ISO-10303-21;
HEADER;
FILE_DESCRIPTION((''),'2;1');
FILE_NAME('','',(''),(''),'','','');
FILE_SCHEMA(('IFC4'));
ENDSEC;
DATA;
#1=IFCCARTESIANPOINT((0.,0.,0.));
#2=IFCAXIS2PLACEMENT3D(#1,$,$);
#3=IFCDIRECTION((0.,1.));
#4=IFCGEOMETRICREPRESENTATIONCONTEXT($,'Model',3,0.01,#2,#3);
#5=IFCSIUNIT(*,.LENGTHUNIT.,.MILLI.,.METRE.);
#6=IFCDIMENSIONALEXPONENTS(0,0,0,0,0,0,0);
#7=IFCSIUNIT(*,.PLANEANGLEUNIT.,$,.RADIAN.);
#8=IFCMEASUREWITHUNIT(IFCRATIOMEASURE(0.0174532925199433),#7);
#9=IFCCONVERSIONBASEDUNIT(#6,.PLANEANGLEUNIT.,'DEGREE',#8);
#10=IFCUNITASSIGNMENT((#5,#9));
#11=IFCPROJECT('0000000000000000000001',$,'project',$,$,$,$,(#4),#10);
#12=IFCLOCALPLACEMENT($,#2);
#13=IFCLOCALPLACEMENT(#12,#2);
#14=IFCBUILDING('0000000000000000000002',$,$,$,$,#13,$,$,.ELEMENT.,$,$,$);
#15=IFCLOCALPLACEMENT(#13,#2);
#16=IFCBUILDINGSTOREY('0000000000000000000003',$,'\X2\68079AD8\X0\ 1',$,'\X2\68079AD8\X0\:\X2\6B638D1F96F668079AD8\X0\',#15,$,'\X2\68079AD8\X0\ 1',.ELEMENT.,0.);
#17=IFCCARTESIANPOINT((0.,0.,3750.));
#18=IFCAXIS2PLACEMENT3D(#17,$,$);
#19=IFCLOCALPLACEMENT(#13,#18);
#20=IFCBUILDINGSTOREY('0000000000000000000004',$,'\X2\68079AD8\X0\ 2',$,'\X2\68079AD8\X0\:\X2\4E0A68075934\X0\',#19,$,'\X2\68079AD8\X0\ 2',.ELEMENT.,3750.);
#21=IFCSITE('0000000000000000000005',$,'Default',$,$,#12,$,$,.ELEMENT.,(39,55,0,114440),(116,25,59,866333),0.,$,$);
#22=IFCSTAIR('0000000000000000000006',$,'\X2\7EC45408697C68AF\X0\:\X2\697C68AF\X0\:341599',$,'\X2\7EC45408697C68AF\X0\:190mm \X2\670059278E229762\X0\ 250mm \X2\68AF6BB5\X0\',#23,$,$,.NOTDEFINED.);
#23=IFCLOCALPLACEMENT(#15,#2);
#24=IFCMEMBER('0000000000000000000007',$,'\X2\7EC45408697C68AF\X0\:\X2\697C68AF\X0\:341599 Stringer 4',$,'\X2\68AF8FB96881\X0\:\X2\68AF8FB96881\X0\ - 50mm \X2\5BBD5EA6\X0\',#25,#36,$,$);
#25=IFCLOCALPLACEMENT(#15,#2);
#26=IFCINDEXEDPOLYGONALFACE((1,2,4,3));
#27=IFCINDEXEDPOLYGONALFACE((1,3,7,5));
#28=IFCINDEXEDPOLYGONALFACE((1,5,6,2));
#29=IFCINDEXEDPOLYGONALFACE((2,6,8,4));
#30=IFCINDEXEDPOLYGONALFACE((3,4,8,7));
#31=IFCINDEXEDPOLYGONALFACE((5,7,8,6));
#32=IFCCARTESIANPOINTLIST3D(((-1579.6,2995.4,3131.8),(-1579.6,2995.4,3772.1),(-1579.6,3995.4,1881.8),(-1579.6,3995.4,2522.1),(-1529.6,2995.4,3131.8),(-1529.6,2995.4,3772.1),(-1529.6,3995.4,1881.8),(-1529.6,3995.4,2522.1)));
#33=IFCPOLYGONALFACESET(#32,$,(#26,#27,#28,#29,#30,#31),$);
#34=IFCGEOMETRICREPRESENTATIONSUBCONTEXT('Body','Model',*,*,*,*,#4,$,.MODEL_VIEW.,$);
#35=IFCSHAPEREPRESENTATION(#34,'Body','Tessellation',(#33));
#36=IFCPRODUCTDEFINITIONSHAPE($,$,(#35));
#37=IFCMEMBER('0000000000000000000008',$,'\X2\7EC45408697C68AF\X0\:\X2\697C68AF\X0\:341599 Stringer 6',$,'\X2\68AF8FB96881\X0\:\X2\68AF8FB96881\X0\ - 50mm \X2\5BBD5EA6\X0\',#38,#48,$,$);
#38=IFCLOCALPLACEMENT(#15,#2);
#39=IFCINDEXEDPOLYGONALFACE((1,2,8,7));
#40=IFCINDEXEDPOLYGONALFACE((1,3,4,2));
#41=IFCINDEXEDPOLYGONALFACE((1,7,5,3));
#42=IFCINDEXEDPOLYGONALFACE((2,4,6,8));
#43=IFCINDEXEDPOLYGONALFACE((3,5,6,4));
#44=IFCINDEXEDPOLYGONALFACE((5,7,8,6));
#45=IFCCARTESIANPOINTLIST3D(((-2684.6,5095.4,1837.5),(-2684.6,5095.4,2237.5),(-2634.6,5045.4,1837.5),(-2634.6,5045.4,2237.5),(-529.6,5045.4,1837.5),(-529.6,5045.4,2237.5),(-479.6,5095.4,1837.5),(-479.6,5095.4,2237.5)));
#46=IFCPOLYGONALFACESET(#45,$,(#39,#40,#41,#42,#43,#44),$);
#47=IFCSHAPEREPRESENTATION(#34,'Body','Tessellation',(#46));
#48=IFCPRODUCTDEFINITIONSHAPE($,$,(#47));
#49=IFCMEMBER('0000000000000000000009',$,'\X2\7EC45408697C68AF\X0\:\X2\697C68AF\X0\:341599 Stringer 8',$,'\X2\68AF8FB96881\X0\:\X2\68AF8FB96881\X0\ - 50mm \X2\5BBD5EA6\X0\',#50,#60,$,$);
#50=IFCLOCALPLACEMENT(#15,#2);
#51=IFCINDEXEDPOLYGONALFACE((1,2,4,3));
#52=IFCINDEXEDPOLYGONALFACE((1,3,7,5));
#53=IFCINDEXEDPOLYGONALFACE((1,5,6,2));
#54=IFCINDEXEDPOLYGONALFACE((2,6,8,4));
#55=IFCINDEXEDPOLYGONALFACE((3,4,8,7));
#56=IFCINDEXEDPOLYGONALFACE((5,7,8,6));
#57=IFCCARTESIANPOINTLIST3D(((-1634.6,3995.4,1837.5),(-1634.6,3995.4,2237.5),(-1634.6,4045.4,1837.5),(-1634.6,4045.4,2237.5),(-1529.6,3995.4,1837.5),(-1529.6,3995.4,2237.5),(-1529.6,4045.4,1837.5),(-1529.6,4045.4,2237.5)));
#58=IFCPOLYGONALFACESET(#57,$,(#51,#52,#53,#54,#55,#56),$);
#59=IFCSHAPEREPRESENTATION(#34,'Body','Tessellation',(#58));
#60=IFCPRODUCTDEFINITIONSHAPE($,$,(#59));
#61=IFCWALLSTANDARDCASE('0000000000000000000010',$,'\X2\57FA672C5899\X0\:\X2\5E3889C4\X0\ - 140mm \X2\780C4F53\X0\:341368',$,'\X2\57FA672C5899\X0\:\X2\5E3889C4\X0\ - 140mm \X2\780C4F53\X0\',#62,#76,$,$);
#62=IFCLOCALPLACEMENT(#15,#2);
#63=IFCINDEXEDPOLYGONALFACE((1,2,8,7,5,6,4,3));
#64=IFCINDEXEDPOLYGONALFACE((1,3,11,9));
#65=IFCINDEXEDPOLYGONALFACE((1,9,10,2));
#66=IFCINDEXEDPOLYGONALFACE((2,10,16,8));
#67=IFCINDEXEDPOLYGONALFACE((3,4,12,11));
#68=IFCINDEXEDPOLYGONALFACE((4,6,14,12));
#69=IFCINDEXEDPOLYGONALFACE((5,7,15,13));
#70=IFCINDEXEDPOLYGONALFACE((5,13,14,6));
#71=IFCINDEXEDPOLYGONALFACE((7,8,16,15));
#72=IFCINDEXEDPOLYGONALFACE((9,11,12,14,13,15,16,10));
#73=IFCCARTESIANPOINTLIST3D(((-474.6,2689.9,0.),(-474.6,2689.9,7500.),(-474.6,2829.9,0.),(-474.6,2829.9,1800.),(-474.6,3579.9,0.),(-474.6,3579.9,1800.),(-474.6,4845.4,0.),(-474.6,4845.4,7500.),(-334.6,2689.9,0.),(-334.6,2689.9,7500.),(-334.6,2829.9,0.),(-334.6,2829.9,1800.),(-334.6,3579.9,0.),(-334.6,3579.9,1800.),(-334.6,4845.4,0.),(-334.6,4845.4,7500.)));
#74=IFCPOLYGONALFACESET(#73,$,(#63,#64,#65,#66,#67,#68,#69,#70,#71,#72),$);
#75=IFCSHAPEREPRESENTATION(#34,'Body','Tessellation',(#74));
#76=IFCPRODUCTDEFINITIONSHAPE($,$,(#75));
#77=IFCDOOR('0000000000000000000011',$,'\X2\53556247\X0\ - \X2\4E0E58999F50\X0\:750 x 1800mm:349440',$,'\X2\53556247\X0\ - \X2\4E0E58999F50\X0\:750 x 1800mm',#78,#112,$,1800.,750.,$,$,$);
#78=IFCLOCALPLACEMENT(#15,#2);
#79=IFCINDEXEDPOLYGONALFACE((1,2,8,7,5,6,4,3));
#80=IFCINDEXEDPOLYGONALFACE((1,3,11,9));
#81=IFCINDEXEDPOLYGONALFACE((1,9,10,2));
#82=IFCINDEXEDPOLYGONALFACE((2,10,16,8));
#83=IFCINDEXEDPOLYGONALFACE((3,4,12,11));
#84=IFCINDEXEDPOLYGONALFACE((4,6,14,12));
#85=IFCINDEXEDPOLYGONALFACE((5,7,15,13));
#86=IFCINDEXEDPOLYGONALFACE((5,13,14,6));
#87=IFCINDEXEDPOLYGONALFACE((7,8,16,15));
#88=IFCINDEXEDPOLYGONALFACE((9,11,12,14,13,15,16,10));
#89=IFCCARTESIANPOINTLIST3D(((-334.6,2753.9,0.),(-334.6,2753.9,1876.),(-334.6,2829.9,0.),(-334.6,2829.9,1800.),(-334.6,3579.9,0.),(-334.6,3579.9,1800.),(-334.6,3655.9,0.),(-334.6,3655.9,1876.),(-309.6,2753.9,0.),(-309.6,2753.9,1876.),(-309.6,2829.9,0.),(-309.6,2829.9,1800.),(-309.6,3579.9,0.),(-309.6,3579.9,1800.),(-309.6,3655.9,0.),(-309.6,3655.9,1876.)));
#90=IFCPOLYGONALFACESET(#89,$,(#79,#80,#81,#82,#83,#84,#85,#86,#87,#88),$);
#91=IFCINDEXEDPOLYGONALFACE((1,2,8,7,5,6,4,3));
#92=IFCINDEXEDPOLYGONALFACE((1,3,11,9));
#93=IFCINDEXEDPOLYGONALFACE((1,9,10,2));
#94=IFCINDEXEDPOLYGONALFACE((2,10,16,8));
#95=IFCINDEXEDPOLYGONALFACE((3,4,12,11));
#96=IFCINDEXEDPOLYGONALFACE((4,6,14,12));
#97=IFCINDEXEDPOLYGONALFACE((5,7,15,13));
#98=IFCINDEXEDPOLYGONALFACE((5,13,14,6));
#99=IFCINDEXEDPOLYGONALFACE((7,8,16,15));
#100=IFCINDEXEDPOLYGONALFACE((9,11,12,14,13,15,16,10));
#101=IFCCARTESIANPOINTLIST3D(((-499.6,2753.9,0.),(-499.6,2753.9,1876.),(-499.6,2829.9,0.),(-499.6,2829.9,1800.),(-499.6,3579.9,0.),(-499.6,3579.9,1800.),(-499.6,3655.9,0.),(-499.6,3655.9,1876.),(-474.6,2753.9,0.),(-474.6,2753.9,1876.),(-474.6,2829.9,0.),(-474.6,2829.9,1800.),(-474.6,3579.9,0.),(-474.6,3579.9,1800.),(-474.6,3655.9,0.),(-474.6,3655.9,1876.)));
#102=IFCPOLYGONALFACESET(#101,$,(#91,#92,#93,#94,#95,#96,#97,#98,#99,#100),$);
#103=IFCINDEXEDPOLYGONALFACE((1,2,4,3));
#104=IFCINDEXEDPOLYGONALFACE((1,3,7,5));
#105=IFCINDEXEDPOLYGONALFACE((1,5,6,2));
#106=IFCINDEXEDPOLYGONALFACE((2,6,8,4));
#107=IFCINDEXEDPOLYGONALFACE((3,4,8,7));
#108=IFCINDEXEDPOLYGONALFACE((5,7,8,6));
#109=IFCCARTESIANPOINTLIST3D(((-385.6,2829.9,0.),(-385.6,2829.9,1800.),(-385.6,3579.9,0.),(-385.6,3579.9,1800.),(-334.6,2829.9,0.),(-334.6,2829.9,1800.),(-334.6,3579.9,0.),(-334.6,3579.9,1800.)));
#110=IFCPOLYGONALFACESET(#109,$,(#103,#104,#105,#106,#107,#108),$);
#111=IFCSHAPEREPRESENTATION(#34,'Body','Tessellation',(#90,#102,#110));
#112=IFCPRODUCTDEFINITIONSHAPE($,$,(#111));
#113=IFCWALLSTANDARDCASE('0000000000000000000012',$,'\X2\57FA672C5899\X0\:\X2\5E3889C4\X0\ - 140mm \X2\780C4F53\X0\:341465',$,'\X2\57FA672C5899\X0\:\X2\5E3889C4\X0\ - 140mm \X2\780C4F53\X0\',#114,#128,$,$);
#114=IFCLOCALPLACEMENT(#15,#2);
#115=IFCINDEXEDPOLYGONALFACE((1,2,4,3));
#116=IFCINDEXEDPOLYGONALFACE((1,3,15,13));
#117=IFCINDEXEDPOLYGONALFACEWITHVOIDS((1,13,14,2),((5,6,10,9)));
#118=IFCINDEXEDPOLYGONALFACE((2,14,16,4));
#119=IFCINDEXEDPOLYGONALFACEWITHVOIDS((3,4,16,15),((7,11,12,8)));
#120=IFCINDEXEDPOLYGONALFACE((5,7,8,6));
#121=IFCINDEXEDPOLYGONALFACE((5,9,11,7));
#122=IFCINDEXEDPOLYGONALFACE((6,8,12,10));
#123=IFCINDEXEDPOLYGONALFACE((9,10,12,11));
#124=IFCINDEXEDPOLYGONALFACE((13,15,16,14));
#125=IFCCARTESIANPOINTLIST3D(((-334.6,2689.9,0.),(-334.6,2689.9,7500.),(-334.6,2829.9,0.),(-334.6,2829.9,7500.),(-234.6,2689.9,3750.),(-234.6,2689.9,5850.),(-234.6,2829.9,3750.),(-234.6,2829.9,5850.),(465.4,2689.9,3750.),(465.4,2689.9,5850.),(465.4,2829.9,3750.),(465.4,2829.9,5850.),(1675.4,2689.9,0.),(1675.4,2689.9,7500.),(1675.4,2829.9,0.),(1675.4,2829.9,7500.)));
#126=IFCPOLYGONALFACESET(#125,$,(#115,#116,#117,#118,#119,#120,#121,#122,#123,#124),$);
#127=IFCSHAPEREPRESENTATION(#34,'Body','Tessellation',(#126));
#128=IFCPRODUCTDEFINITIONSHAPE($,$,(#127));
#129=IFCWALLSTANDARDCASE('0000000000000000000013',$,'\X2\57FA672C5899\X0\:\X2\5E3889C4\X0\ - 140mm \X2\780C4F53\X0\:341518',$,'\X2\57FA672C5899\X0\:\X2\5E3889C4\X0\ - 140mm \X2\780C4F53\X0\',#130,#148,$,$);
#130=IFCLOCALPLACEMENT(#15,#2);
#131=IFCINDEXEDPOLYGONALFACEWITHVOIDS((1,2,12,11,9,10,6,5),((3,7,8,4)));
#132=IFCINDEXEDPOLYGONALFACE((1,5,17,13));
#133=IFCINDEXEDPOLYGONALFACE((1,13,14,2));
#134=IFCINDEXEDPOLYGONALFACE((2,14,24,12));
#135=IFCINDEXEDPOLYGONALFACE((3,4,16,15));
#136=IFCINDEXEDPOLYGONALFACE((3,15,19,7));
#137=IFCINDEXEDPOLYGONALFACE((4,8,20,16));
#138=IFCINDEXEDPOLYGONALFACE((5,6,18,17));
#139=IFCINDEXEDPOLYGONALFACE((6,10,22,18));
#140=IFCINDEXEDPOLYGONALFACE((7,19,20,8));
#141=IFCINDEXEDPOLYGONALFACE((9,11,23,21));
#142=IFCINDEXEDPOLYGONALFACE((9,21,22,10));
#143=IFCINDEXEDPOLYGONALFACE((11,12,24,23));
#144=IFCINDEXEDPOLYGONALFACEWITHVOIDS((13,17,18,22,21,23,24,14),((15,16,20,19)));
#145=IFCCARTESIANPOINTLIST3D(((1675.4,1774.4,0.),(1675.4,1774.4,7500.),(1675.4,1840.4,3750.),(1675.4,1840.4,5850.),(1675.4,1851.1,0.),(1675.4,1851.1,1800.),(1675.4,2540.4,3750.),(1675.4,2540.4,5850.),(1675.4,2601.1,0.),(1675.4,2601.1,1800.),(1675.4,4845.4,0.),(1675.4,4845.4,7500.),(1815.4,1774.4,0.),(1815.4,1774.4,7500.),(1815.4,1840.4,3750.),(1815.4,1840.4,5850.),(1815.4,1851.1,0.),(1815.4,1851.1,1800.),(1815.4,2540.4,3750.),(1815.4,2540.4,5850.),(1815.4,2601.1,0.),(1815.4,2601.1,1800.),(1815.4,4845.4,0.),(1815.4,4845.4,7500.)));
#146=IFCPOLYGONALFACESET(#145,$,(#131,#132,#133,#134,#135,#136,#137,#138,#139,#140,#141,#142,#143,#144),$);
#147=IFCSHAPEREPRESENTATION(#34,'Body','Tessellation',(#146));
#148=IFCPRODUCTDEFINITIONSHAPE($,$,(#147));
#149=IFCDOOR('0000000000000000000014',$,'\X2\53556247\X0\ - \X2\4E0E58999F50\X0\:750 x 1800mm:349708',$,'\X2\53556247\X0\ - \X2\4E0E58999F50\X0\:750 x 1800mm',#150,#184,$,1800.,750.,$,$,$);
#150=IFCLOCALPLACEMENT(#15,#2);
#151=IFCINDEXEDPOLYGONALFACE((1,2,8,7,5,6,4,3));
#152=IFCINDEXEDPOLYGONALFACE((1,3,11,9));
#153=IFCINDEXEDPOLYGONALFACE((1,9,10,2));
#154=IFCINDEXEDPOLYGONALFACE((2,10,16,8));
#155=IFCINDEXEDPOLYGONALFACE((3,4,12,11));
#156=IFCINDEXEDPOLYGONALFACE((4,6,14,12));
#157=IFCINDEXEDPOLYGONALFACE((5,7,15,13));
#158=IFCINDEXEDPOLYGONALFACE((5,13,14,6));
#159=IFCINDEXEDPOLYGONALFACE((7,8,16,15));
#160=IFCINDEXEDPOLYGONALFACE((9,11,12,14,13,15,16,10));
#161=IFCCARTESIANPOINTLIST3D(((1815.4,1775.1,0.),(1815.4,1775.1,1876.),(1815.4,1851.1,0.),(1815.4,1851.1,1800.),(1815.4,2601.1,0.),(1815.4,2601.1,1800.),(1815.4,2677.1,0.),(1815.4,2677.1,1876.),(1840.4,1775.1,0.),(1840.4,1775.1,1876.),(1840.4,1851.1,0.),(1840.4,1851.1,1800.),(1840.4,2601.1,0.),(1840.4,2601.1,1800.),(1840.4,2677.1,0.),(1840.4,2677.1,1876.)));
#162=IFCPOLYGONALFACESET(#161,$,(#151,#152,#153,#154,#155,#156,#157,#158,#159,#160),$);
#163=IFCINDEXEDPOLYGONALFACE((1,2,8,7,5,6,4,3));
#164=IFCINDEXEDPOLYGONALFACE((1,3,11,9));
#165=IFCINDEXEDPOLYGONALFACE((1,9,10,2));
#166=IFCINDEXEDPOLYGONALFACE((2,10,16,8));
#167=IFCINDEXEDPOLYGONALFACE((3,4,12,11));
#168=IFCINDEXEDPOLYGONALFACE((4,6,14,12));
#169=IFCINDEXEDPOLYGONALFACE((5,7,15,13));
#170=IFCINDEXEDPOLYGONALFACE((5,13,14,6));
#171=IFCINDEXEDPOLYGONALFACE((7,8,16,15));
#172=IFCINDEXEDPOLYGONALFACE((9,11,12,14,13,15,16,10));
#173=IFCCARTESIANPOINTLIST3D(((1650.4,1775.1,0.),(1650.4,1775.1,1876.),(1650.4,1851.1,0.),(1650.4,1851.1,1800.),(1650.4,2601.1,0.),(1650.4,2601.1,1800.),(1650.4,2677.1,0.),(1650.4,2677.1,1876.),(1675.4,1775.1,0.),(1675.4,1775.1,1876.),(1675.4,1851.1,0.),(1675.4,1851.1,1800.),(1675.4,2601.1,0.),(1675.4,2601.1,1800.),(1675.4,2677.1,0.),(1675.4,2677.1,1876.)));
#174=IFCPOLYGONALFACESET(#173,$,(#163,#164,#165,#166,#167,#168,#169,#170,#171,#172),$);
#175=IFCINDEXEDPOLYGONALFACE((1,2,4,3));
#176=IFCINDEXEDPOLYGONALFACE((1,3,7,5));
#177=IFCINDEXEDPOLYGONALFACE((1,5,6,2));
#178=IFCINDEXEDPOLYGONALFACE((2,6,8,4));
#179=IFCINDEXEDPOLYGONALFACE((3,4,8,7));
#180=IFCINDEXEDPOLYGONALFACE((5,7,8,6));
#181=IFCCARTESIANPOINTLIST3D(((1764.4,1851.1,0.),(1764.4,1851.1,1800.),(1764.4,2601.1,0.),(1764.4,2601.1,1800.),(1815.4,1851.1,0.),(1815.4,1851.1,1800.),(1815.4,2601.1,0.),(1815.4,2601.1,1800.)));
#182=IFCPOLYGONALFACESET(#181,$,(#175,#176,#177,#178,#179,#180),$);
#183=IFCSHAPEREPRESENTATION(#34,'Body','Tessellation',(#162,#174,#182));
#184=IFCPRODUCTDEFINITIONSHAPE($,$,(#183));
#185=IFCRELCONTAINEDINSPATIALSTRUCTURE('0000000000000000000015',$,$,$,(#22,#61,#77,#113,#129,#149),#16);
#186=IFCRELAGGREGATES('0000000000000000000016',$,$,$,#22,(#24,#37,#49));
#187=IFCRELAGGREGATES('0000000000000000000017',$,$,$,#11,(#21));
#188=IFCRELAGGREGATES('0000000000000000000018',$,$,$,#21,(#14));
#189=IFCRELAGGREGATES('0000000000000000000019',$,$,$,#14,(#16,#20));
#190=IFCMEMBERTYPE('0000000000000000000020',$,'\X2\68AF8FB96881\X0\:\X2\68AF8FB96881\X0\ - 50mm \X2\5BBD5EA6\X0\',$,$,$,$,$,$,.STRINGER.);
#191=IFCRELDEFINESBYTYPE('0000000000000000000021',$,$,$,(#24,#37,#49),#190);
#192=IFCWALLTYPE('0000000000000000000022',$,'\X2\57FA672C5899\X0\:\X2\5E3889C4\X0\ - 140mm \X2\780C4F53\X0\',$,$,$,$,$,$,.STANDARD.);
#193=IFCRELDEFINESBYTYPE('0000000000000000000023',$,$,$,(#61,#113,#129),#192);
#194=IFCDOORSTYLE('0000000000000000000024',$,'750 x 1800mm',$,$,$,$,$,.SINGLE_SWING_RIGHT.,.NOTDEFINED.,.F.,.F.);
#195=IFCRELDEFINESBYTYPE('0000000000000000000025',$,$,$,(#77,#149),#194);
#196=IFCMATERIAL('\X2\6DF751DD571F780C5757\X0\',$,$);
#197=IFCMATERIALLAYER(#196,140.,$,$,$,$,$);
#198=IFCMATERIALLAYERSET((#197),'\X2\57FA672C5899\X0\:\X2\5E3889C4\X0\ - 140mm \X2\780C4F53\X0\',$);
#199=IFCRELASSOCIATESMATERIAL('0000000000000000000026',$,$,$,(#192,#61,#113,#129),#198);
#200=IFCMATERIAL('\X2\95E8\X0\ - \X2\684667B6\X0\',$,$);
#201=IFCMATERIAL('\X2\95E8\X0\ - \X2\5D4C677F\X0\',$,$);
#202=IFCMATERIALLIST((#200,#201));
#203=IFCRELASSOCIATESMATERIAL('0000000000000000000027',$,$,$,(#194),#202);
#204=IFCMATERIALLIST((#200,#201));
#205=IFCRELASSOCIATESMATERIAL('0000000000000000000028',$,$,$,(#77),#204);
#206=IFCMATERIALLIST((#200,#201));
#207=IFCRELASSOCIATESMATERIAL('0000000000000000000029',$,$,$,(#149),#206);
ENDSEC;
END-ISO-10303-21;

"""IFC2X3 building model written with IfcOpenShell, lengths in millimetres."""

from ifc_helpers import new_model, entity, si_unit, converted_unit, direction, frame, frame_2d, origin, place, context, subcontext, project, spatial, polyline, rectangle, outline, extrude, source, transform, mapped, material, material_list, layer, layer_set, layer_usage, type_object, type_shapes, element, fill, aggregate, save


model = new_model("IFC2X3")

# Units and contexts
model_context = context("Model", 3, precision=0.01, world=origin(), true_north=direction((0.0, 1.0)))
body_context = subcontext(model_context, "Body", "Model", "MODEL_VIEW")
ifc_project = project(units=[si_unit("LENGTHUNIT", "METRE", prefix="MILLI"), converted_unit("PLANEANGLEUNIT", "DEGREE", entity("IfcRatioMeasure", 0.0174532925199433), si_unit("PLANEANGLEUNIT", "RADIAN"), dimensions=[0, 0, 0, 0, 0, 0, 0])], contexts=[model_context])

# Site, building, storey
site_placement = place(None, origin())
site = spatial("IfcSite", under=ifc_project, at=site_placement, Name="Default", CompositionType="ELEMENT", RefLatitude=(39, 55, 0, 114440), RefLongitude=(116, 25, 59, 866333), RefElevation=0.0)
building_placement = place(site_placement, origin())
building = spatial("IfcBuilding", under=site, at=building_placement, CompositionType="ELEMENT")
storey_1_placement = place(building_placement, origin())
storey_1 = spatial("IfcBuildingStorey", under=building, at=storey_1_placement, Name="标高 1", ObjectType="标高:正负零标高", LongName="标高 1", CompositionType="ELEMENT", Elevation=0.0)

# Stair, members
stair_placement = place(storey_1_placement, origin())
stair = element("IfcStair", 1, at=stair_placement, inside=storey_1, Name="组合楼梯:楼梯:341599", ObjectType="组合楼梯:190mm 最大踢面 250mm 梯段", ShapeType="NOTDEFINED")
member_type = type_object("IfcMemberType", Name="梯边梁:梯边梁 - 50mm 宽度", PredefinedType="STRINGER")
member_1_placement = place(stair_placement, origin())
member_1 = element("IfcMember", 2, at=member_1_placement, type_object=member_type, Name="组合楼梯:楼梯:341599 Stringer 4", ObjectType="梯边梁:梯边梁 - 50mm 宽度", context=body_context, shape_type="SweptSolid", body=[
    extrude(outline(polyline([(-550.4, -200.0), (1050.4, -200.0), (550.4, 200.0), (-1050.4, 200.0), (-550.4, -200.0)])), frame((-1579.6, 3495.4, 2826.9), z_axis=(1.0, 0.0, 0.0), x_axis=(0.0, -0.624695, 0.780869)), (0.0, 0.0, 1.0), 50.0),
])
member_2_placement = place(stair_placement, origin())
member_2 = element("IfcMember", 3, at=member_2_placement, type_object=member_type, Name="组合楼梯:楼梯:341599 Stringer 6", ObjectType="梯边梁:梯边梁 - 50mm 宽度", context=body_context, shape_type="SweptSolid", body=[
    extrude(outline(polyline([(-1102.5, -25.0), (1102.5, -25.0), (1052.5, 25.0), (-1052.5, 25.0), (-1102.5, -25.0)])), frame((-1582.1, 5070.4, 1837.5), z_axis=(0.0, 0.0, 1.0), x_axis=(-1.0, 0.0, 0.0)), (0.0, 0.0, 1.0), 400.0),
])
member_3_placement = place(stair_placement, origin())
member_3 = element("IfcMember", 4, at=member_3_placement, type_object=member_type, Name="组合楼梯:楼梯:341599 Stringer 8", ObjectType="梯边梁:梯边梁 - 50mm 宽度", context=body_context, shape_type="SweptSolid", body=[
    extrude(rectangle(XDim=105.0, YDim=50.0, at=frame_2d((0.0, 0.0), x_axis=(1.0, 0.0))), frame((-1582.1, 4020.4, 1837.5)), (0.0, 0.0, 1.0), 400.0),
])

# Shared definitions
ifc_material_1 = material(Name="混凝土砌块")
ifc_layer_1 = layer(ifc_material_1, 140.0)
ifc_layer_set_1 = layer_set([ifc_layer_1], Name="基本墙:常规 - 140mm 砌体")
wall_type = type_object("IfcWallType", Name="基本墙:常规 - 140mm 砌体", PredefinedType="STANDARD", material=ifc_layer_set_1)

# Shared definitions
storey_2_placement = place(building_placement, frame((0.0, 0.0, 3750.0)))
storey_2 = spatial("IfcBuildingStorey", under=building, at=storey_2_placement, Name="标高 2", ObjectType="标高:上标头", LongName="标高 2", CompositionType="ELEMENT", Elevation=3750.0)

# Shared definitions
ifc_material_2 = material(Name="门 - 框架")
ifc_material_3 = material(Name="门 - 嵌板")

# Wall, opening, door
ifc_layer_usage_1 = layer_usage(ifc_layer_set_1, "AXIS2", "NEGATIVE", 70.0)
wall_1_placement = place(storey_1_placement, frame((-404.6, 2689.9, 0.0), z_axis=(0.0, 0.0, 1.0), x_axis=(0.0, 1.0, 0.0)))
wall_1 = element("IfcWallStandardCase", 5, at=wall_1_placement, inside=storey_1, type_object=wall_type, material=ifc_layer_usage_1, Name="基本墙:常规 - 140mm 砌体:341368", ObjectType="基本墙:常规 - 140mm 砌体", context=body_context, shape_type="SweptSolid", body=[
    extrude(rectangle(XDim=2155.5, YDim=140.0, at=frame_2d((1077.8, 0.0), x_axis=(-1.0, 0.0))), origin(), (0.0, 0.0, 1.0), 7500.0),
])
opening_1_placement = place(wall_1_placement, frame((890.0, 70.0, 0.0)))
opening_1 = element("IfcOpeningElement", 6, at=opening_1_placement, cuts=wall_1, ObjectType="Opening", context=body_context, shape_type="SweptSolid", body=[
    extrude(rectangle(XDim=750.0, YDim=1800.0, at=frame_2d((900.0, 375.0), x_axis=(0.0, 1.0))), frame((0.0, 0.0, 0.0), z_axis=(0.0, -1.0, 0.0), x_axis=(0.0, 0.0, 1.0)), (0.0, 0.0, 1.0), 140.0),
])
ifc_material_list_1 = material_list([ifc_material_2, ifc_material_3])
ifc_material_list_2 = material_list([ifc_material_2, ifc_material_3])
door_style_1 = type_object("IfcDoorStyle", Name="750 x 1800mm", ConstructionType="NOTDEFINED", OperationType="SINGLE_SWING_RIGHT", ParameterTakesPrecedence=False, Sizeable=False, material=ifc_material_list_2)
shared_shape_1 = source(origin(), body_context, "Body", "SweptSolid", [
    extrude(outline(polyline([(-451.0, -957.0), (451.0, -957.0), (451.0, 919.0), (375.0, 919.0), (375.0, -881.0), (-375.0, -881.0), (-375.0, 919.0), (-451.0, 919.0), (-451.0, -957.0)])), frame((375.0, 140.0, 919.0), z_axis=(0.0, 1.0, 0.0), x_axis=(1.0, 0.0, 0.0)), (0.0, 0.0, 1.0), 25.0),
    extrude(outline(polyline([(-957.0, -451.0), (919.0, -451.0), (919.0, -375.0), (-881.0, -375.0), (-881.0, 375.0), (919.0, 375.0), (919.0, 451.0), (-957.0, 451.0), (-957.0, -451.0)])), frame((375.0, -25.0, 919.0), z_axis=(0.0, 1.0, 0.0), x_axis=(0.0, 0.0, -1.0)), (0.0, 0.0, 1.0), 25.0),
    extrude(rectangle(XDim=51.0, YDim=750.0, at=frame_2d((0.0, 0.0), x_axis=(1.0, 0.0))), frame((375.0, 114.5, 0.0), z_axis=(0.0, 0.0, 1.0), x_axis=(0.0, 1.0, 0.0)), (0.0, 0.0, 1.0), 1800.0),
])
type_shapes(door_style_1, [shared_shape_1])
door_1_placement = place(opening_1_placement, frame((0.0, 0.0, 0.0), z_axis=(0.0, 0.0, 1.0), x_axis=(-1.0, 0.0, 0.0)))
door_1 = element("IfcDoor", 7, at=door_1_placement, inside=storey_1, type_object=door_style_1, material=ifc_material_list_1, Name="单扇 - 与墙齐:750 x 1800mm:349440", ObjectType="单扇 - 与墙齐:750 x 1800mm", OverallHeight=1800.0, OverallWidth=750.0, context=body_context, shape_type="MappedRepresentation", body=[
    mapped(shared_shape_1, transform((0.0, 0.0, 0.0), scale=1.0)),
])
fill(opening_1, door_1)

# Wall, opening
ifc_layer_usage_2 = layer_usage(ifc_layer_set_1, "AXIS2", "NEGATIVE", 70.0)
wall_2_placement = place(storey_1_placement, frame((-334.6, 2759.9, 0.0)))
wall_2 = element("IfcWallStandardCase", 8, at=wall_2_placement, inside=storey_1, type_object=wall_type, material=ifc_layer_usage_2, Name="基本墙:常规 - 140mm 砌体:341465", ObjectType="基本墙:常规 - 140mm 砌体", context=body_context, shape_type="SweptSolid", body=[
    extrude(rectangle(XDim=2010.0, YDim=140.0, at=frame_2d((1005.0, 0.0), x_axis=(-1.0, 0.0))), origin(), (0.0, 0.0, 1.0), 7500.0),
])
opening_2_placement = place(wall_2_placement, frame((100.0, -70.0, 3750.0)))
element("IfcOpeningElement", 9, at=opening_2_placement, cuts=wall_2, ObjectType="Opening", context=body_context, shape_type="SweptSolid", body=[
    extrude(rectangle(XDim=2100.0, YDim=700.0, at=frame_2d((1050.0, 350.0), x_axis=(1.0, 0.0))), frame((0.0, 0.0, 0.0), z_axis=(0.0, 1.0, 0.0), x_axis=(0.0, 0.0, 1.0)), (0.0, 0.0, 1.0), 140.0),
])

# Wall, openings, door
ifc_layer_usage_3 = layer_usage(ifc_layer_set_1, "AXIS2", "NEGATIVE", 70.0)
wall_3_placement = place(storey_1_placement, frame((1745.4, 1774.4, 0.0), z_axis=(0.0, 0.0, 1.0), x_axis=(0.0, 1.0, 0.0)))
wall_3 = element("IfcWallStandardCase", 10, at=wall_3_placement, inside=storey_1, type_object=wall_type, material=ifc_layer_usage_3, Name="基本墙:常规 - 140mm 砌体:341518", ObjectType="基本墙:常规 - 140mm 砌体", context=body_context, shape_type="SweptSolid", body=[
    extrude(rectangle(XDim=3071.0, YDim=140.0, at=frame_2d((1535.5, 0.0), x_axis=(-1.0, 0.0))), origin(), (0.0, 0.0, 1.0), 7500.0),
])
opening_3_placement = place(wall_3_placement, frame((826.8, 70.0, 0.0)))
opening_3 = element("IfcOpeningElement", 11, at=opening_3_placement, cuts=wall_3, ObjectType="Opening", context=body_context, shape_type="SweptSolid", body=[
    extrude(rectangle(XDim=750.0, YDim=1800.0, at=frame_2d((900.0, 375.0), x_axis=(0.0, 1.0))), frame((0.0, 0.0, 0.0), z_axis=(0.0, -1.0, 0.0), x_axis=(0.0, 0.0, 1.0)), (0.0, 0.0, 1.0), 140.0),
])
opening_4_placement = place(wall_3_placement, frame((766.0, 70.0, 3750.0)))
element("IfcOpeningElement", 12, at=opening_4_placement, cuts=wall_3, ObjectType="Opening", context=body_context, shape_type="SweptSolid", body=[
    extrude(rectangle(XDim=2100.0, YDim=700.0, at=frame_2d((1050.0, 350.0), x_axis=(1.0, 0.0))), frame((0.0, 0.0, 0.0), z_axis=(0.0, -1.0, 0.0), x_axis=(0.0, 0.0, 1.0)), (0.0, 0.0, 1.0), 140.0),
])
ifc_material_list_3 = material_list([ifc_material_2, ifc_material_3])
door_2_placement = place(opening_3_placement, frame((0.0, 0.0, 0.0), z_axis=(0.0, 0.0, 1.0), x_axis=(-1.0, 0.0, 0.0)))
door_2 = element("IfcDoor", 13, at=door_2_placement, inside=storey_1, type_object=door_style_1, material=ifc_material_list_3, Name="单扇 - 与墙齐:750 x 1800mm:349708", ObjectType="单扇 - 与墙齐:750 x 1800mm", OverallHeight=1800.0, OverallWidth=750.0, context=body_context, shape_type="MappedRepresentation", body=[
    mapped(shared_shape_1, transform((0.0, 0.0, 0.0), scale=1.0)),
])
fill(opening_3, door_2)

aggregate(stair, [member_1, member_2, member_3])

save(model, "model.ifc")
